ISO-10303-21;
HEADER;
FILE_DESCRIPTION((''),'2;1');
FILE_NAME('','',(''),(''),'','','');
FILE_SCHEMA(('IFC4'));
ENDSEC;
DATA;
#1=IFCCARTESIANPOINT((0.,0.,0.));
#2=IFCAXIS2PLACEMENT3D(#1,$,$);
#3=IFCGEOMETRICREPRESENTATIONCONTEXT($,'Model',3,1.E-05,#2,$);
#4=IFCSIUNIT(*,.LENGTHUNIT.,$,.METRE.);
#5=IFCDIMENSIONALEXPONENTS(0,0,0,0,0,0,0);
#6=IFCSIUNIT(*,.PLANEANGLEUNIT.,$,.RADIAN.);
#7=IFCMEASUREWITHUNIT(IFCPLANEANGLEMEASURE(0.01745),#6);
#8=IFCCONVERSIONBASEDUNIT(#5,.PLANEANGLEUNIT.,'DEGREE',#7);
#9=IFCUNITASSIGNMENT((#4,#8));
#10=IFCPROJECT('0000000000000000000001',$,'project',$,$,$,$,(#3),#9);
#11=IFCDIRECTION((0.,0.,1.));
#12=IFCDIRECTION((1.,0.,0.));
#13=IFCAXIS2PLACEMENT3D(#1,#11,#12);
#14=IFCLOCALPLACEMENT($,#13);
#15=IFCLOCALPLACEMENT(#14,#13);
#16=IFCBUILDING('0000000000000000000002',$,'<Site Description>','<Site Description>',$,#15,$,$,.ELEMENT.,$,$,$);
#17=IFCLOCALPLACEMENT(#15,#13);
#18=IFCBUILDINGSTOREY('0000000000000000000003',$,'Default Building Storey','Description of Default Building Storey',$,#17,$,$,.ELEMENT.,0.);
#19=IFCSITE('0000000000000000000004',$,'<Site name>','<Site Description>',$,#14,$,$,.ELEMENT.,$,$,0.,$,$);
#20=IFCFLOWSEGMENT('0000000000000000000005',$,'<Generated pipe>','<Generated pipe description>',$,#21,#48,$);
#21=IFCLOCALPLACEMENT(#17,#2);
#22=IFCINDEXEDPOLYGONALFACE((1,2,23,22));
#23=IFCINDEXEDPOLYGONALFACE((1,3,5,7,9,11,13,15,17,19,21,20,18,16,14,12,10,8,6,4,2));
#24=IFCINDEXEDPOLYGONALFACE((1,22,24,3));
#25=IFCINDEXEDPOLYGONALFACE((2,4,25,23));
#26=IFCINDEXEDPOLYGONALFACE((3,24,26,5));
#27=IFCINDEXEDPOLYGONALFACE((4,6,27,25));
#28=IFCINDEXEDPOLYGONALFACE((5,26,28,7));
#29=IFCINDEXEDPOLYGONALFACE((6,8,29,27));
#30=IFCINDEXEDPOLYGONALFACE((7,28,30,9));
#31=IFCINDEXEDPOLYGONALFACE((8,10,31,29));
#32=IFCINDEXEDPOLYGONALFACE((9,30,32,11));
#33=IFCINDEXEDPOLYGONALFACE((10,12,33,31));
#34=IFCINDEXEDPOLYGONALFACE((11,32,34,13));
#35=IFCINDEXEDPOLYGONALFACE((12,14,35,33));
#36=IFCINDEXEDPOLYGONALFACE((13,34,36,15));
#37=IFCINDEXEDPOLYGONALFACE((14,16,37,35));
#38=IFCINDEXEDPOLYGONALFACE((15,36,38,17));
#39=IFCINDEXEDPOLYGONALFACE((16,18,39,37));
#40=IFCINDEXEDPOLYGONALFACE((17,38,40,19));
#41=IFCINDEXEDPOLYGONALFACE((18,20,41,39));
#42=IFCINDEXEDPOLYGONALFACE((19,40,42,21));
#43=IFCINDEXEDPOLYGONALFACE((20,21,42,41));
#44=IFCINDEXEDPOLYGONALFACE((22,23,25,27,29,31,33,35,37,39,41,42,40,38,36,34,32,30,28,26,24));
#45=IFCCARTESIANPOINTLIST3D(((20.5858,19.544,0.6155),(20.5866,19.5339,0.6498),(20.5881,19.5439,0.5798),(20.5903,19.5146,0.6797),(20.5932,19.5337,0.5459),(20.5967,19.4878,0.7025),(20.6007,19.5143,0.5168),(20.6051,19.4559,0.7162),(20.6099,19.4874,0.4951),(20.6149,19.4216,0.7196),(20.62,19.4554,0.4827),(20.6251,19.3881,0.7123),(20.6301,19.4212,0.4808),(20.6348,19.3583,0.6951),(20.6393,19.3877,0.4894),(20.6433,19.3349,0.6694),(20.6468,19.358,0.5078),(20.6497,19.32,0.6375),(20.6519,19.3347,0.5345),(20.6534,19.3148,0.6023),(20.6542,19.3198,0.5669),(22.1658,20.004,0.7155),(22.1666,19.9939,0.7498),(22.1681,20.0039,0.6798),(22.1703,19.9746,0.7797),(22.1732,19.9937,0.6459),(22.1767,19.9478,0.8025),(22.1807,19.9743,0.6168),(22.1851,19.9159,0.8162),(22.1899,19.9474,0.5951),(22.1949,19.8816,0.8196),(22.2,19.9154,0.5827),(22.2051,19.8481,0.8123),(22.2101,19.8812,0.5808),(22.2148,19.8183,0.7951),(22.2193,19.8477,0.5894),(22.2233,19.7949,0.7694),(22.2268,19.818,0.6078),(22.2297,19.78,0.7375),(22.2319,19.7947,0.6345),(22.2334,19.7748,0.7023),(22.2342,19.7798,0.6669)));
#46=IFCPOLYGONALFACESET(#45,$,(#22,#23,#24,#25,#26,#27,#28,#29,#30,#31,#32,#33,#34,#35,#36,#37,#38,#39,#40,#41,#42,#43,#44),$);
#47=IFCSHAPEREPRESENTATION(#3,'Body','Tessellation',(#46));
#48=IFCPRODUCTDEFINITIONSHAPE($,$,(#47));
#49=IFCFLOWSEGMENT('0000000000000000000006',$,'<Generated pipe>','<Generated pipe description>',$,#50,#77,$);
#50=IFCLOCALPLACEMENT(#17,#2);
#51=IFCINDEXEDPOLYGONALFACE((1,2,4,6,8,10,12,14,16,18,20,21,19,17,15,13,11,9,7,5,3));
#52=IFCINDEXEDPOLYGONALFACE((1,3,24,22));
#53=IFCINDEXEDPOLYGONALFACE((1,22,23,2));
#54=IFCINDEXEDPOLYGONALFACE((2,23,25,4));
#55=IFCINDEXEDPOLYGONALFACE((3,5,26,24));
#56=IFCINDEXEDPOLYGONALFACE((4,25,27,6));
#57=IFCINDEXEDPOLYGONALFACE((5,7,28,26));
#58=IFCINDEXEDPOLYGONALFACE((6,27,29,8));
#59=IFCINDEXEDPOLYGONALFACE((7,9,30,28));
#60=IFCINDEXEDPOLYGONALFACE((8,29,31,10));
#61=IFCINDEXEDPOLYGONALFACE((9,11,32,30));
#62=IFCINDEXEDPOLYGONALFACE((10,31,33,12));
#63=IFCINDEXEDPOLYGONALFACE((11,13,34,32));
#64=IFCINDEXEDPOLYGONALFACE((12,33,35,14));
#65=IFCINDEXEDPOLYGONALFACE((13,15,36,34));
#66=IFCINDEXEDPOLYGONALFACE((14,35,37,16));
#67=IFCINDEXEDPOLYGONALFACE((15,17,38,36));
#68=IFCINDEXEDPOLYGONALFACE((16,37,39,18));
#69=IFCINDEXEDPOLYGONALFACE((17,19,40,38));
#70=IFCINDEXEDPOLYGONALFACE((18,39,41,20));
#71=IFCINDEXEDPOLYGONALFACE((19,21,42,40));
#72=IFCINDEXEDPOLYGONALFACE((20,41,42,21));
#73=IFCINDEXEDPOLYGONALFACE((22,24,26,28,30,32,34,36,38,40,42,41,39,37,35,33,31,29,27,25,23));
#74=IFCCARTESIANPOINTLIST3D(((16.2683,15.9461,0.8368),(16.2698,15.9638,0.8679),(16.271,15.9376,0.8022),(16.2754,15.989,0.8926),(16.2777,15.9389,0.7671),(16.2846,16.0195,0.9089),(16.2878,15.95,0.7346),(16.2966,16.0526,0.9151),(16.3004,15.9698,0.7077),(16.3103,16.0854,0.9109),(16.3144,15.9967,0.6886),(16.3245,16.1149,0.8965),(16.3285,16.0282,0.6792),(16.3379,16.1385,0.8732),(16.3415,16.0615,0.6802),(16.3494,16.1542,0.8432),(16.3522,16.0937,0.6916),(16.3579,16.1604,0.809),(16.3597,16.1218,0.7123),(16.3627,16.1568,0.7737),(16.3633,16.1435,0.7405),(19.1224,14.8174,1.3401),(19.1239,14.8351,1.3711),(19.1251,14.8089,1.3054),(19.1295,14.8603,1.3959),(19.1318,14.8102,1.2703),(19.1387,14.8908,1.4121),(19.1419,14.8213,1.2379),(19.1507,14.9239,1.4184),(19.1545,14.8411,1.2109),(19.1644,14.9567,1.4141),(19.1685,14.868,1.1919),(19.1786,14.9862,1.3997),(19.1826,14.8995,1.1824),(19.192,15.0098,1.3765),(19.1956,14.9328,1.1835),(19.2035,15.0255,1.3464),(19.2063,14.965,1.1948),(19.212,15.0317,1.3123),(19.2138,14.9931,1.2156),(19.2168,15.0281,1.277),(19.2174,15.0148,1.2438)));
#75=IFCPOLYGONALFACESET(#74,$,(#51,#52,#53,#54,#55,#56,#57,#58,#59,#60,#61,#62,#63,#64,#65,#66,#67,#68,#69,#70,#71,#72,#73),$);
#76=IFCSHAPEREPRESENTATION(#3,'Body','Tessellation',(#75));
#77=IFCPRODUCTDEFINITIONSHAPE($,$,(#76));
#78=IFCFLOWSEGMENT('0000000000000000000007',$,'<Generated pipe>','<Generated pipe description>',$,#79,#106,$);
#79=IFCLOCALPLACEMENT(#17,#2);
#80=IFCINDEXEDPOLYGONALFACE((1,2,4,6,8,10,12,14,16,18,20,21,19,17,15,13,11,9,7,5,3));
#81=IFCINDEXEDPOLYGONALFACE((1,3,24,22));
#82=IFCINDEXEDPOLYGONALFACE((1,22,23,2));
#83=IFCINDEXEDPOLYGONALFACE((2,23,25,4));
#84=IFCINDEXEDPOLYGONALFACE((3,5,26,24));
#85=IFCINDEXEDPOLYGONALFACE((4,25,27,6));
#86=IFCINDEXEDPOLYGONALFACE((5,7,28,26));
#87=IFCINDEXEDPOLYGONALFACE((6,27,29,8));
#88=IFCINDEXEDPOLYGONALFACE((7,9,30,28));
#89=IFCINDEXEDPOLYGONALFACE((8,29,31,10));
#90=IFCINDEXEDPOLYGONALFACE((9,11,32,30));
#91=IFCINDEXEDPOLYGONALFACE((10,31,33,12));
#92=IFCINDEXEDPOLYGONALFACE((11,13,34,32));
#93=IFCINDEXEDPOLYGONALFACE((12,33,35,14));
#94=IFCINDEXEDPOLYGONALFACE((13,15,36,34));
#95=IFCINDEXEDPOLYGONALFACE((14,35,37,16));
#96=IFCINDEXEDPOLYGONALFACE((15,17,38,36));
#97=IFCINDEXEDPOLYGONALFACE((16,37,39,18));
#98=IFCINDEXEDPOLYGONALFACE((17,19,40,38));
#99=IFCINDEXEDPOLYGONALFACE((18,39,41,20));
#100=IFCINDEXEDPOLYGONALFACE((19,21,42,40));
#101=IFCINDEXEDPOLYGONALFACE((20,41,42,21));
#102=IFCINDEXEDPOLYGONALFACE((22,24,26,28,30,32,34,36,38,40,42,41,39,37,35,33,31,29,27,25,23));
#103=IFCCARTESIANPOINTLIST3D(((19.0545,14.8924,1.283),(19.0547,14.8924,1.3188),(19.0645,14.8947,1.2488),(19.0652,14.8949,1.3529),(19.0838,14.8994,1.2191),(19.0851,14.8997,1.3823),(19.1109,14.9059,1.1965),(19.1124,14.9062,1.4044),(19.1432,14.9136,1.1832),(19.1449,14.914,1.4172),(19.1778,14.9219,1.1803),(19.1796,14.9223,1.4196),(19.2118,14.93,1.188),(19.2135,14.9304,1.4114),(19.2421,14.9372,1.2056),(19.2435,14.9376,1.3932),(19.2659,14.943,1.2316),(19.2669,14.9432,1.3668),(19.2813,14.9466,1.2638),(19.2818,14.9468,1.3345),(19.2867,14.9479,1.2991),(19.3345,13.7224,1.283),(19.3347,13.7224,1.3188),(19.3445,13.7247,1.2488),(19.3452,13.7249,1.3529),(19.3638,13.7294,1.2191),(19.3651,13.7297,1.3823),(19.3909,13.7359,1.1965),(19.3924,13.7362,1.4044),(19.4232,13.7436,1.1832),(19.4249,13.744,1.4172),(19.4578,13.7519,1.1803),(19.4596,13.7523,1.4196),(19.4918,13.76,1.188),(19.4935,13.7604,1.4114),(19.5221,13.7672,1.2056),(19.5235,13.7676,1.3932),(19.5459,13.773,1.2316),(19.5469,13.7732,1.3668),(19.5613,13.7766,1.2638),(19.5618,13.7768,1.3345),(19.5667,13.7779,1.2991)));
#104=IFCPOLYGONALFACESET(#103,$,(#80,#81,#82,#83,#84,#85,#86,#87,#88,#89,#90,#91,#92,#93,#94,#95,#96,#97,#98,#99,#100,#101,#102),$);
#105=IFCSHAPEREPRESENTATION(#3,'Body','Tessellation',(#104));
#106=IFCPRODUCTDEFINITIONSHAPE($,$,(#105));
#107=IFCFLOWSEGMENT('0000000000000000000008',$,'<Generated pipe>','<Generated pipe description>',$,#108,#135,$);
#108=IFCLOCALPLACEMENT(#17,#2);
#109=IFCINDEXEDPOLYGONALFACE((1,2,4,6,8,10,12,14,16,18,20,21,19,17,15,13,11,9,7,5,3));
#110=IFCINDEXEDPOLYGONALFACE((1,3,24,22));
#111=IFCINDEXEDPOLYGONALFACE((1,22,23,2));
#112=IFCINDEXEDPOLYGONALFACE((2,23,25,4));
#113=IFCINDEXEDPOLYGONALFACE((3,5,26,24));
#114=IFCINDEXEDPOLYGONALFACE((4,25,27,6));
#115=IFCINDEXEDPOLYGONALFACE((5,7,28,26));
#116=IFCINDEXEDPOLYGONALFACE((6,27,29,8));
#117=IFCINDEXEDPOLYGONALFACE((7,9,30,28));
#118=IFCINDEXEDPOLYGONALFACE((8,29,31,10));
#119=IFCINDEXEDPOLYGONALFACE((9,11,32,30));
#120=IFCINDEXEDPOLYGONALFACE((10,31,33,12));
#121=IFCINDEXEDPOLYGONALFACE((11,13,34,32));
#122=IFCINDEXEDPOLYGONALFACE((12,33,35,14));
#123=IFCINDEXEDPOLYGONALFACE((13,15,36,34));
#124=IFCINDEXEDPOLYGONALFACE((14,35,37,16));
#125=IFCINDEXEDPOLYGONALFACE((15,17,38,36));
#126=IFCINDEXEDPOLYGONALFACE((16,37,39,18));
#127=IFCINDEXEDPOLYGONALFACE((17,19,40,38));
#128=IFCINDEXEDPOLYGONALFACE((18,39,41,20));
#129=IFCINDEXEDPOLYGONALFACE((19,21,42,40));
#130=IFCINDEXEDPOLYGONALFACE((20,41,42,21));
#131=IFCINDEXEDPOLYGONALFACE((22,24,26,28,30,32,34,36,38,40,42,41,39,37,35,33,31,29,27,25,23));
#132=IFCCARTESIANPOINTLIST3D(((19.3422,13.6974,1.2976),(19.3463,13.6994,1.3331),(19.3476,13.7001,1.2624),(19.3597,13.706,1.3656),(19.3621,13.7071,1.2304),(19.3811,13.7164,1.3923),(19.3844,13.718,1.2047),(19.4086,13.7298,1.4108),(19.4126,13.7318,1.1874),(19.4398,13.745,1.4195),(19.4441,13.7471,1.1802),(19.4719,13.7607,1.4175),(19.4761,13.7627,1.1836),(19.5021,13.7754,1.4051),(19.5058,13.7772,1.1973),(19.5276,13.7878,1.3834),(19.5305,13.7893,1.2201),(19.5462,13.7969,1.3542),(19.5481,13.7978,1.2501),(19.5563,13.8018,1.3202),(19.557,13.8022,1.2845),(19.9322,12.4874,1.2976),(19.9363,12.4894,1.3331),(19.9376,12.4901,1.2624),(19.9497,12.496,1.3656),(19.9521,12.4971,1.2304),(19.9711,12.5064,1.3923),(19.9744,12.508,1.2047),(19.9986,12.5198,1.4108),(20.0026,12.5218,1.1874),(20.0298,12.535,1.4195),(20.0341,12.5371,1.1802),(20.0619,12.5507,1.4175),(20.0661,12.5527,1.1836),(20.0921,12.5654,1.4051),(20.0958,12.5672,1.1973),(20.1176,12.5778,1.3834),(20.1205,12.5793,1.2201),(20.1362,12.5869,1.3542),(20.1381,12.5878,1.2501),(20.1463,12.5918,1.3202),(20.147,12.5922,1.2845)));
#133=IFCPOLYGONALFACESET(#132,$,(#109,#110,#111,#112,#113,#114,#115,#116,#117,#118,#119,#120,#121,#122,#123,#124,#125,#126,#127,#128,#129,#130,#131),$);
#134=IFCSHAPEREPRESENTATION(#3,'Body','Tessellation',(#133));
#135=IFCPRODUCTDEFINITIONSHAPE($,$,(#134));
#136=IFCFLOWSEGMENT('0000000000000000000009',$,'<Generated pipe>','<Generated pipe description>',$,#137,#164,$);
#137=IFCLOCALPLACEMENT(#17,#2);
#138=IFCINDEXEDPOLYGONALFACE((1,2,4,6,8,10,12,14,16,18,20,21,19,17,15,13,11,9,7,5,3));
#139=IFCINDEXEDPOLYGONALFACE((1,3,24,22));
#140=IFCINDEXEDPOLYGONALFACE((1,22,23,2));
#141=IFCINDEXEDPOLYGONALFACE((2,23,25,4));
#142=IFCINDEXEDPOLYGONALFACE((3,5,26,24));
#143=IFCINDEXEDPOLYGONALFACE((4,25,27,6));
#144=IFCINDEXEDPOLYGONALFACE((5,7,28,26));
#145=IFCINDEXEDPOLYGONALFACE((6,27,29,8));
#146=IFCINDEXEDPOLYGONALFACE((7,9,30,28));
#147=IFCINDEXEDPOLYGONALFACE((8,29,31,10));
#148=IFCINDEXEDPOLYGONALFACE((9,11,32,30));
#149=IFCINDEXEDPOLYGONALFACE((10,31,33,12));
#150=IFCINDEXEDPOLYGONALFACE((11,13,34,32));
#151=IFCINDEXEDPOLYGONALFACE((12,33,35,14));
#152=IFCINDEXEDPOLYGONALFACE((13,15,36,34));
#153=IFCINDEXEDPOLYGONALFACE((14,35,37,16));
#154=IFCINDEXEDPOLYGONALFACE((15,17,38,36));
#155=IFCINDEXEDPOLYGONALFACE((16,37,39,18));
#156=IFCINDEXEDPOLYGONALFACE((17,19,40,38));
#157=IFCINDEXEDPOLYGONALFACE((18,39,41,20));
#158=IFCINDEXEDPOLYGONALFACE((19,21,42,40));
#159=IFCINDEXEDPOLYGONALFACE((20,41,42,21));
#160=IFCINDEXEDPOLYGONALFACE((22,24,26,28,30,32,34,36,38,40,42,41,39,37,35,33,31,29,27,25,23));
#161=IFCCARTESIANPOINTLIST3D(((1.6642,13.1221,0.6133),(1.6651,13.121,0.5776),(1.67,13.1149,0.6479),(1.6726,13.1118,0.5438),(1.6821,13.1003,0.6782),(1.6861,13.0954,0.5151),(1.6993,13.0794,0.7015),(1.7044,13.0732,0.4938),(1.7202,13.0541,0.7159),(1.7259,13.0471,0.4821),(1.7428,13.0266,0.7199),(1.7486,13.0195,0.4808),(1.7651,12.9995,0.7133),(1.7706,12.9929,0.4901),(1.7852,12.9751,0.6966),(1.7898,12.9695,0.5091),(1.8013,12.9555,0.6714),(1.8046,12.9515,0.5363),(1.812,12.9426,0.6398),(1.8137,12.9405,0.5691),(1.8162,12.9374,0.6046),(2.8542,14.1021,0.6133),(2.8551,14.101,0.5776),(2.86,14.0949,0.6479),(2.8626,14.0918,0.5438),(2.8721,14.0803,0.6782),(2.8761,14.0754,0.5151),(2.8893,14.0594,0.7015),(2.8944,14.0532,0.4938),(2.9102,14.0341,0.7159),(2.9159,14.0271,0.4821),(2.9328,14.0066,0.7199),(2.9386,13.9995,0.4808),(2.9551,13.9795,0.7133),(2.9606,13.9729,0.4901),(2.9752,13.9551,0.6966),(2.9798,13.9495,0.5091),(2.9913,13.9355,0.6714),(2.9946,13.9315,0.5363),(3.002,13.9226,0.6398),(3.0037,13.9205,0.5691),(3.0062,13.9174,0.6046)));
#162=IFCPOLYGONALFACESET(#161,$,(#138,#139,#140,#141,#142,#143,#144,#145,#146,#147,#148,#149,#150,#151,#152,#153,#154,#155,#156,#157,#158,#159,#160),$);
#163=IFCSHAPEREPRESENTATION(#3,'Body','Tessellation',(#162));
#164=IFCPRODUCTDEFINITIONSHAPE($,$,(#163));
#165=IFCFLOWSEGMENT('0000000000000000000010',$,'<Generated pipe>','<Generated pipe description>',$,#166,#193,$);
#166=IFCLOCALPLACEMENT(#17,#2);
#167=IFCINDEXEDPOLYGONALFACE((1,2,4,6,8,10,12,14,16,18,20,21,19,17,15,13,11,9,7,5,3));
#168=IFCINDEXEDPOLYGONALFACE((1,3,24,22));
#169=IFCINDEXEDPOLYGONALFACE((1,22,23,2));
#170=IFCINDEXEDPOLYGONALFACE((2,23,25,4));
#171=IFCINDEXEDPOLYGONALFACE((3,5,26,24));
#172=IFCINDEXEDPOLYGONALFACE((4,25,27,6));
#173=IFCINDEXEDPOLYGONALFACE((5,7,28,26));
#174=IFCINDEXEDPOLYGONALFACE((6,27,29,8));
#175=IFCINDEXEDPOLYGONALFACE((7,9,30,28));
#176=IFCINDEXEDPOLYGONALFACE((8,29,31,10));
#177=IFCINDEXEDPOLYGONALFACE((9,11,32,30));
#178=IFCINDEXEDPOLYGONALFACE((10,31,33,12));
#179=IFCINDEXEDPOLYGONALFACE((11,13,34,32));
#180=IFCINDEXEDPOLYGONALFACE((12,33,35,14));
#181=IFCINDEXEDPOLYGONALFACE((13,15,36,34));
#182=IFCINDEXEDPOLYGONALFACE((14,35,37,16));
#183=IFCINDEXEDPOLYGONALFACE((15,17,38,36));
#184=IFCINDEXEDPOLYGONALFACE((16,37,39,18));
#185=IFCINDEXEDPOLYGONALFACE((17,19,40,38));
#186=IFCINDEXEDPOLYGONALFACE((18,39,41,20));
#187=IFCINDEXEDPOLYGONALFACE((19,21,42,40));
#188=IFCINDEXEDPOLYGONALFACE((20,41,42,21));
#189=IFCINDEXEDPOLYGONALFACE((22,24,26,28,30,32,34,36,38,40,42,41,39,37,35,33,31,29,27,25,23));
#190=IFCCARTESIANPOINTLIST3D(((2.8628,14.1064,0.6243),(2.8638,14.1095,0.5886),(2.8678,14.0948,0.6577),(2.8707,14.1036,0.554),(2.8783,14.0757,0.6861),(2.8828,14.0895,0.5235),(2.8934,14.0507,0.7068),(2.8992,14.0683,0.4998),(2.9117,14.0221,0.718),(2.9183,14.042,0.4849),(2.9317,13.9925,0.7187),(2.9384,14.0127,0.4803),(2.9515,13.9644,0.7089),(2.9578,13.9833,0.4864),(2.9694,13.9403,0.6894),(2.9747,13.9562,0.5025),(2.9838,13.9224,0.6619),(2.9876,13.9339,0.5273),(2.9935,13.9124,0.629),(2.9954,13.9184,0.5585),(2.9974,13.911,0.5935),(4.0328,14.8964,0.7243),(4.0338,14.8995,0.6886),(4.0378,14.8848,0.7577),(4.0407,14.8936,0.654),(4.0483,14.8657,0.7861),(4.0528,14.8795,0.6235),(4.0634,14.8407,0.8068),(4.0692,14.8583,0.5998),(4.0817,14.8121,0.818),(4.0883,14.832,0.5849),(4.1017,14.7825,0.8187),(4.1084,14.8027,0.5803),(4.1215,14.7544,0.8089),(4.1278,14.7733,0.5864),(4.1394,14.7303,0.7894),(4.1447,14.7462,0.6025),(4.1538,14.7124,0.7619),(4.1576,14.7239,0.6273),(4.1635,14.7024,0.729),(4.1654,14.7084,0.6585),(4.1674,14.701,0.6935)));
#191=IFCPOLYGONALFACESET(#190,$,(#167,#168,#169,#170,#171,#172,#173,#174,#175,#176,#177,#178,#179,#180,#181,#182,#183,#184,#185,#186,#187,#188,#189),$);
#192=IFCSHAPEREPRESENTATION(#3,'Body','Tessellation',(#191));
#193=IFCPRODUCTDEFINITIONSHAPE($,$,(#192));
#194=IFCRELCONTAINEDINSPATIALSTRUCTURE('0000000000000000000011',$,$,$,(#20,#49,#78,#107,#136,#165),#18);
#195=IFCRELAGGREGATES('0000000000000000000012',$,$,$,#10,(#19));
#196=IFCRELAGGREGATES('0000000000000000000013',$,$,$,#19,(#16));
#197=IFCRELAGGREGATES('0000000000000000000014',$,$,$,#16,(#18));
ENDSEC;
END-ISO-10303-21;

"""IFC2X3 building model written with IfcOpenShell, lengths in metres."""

from ifc_helpers import new_model, entity, si_unit, converted_unit, frame, origin, origin_with_axes, origin_2d_with_axis, place, context, project, spatial, circle, extrude, element, save


model = new_model("IFC2X3")

# Units and contexts
model_context = context("Model", 3, precision=1e-05, world=origin())
ifc_project = project(units=[si_unit("LENGTHUNIT", "METRE"), converted_unit("PLANEANGLEUNIT", "DEGREE", entity("IfcPlaneAngleMeasure", 0.01745), si_unit("PLANEANGLEUNIT", "RADIAN"), dimensions=[0, 0, 0, 0, 0, 0, 0])], contexts=[model_context])

# Site, building, storey
site_placement = place(None, origin_with_axes())
site = spatial("IfcSite", under=ifc_project, at=site_placement, Name="<Site name>", Description="<Site Description>", CompositionType="ELEMENT", RefElevation=0.0)
building_placement = place(site_placement, origin_with_axes())
building = spatial("IfcBuilding", under=site, at=building_placement, Name="<Site Description>", Description="<Site Description>", CompositionType="ELEMENT")
storey_placement = place(building_placement, origin_with_axes())
storey = spatial("IfcBuildingStorey", under=building, at=storey_placement, Name="Default Building Storey", Description="Description of Default Building Storey", CompositionType="ELEMENT", Elevation=0.0)

# Flow segments
flow_segment_1_placement = place(storey_placement, frame((20.62, 19.43, 0.6), z_axis=(0.958368, 0.279019, 0.060656), x_axis=(-0.124035, 0.215469, 0.968601)))
element("IfcFlowSegment", 1, at=flow_segment_1_placement, inside=storey, Name="<Generated pipe>", Description="<Generated pipe description>", context=model_context, shape_type="SweptSolid", body=[
    extrude(circle(Radius=0.12, at=origin_2d_with_axis()), origin_with_axes(), (0.0, 0.0, 1.0), 1.6486),
])
flow_segment_2_placement = place(storey_placement, frame((16.3159, 16.0487, 0.7968), z_axis=(0.91767, -0.362907, 0.161806), x_axis=(-0.046782, 0.305707, 0.950976)))
element("IfcFlowSegment", 2, at=flow_segment_2_placement, inside=storey, Name="<Generated pipe>", Description="<Generated pipe description>", context=model_context, shape_type="SweptSolid", body=[
    extrude(circle(Radius=0.12, at=origin_2d_with_axis()), origin_with_axes(), (0.0, 0.0, 1.0), 3.1102),
])
flow_segment_3_placement = place(storey_placement, frame((19.17, 14.92, 1.3), z_axis=(0.232744, -0.972538, 0.0), x_axis=(0.612131, 0.146493, 0.777069)))
element("IfcFlowSegment", 3, at=flow_segment_3_placement, inside=storey, Name="<Generated pipe>", Description="<Generated pipe description>", context=model_context, shape_type="SweptSolid", body=[
    extrude(circle(Radius=0.12, at=origin_2d_with_axis()), origin_with_axes(), (0.0, 0.0, 1.0), 1.203),
])
flow_segment_4_placement = place(storey_placement, frame((19.45, 13.75, 1.3), z_axis=(0.438277, -0.89884, 0.0), x_axis=(0.433825, 0.211535, 0.875813)))
element("IfcFlowSegment", 4, at=flow_segment_4_placement, inside=storey, Name="<Generated pipe>", Description="<Generated pipe description>", context=model_context, shape_type="SweptSolid", body=[
    extrude(circle(Radius=0.12, at=origin_2d_with_axis()), origin_with_axes(), (0.0, 0.0, 1.0), 1.3462),
])
flow_segment_5_placement = place(storey_placement, frame((1.74, 13.03, 0.6), z_axis=(0.77193, 0.635707, 0.0), x_axis=(0.599796, -0.728324, 0.331345)))
element("IfcFlowSegment", 5, at=flow_segment_5_placement, inside=storey, Name="<Generated pipe>", Description="<Generated pipe description>", context=model_context, shape_type="SweptSolid", body=[
    extrude(circle(Radius=0.12, at=origin_2d_with_axis()), origin_with_axes(), (0.0, 0.0, 1.0), 1.5416),
])
flow_segment_6_placement = place(storey_placement, frame((2.93, 14.01, 0.6), z_axis=(0.826695, 0.558196, 0.070658), x_axis=(-0.559842, 0.803528, 0.202286)))
element("IfcFlowSegment", 6, at=flow_segment_6_placement, inside=storey, Name="<Generated pipe>", Description="<Generated pipe description>", context=model_context, shape_type="SweptSolid", body=[
    extrude(circle(Radius=0.12, at=origin_2d_with_axis()), origin_with_axes(), (0.0, 0.0, 1.0), 1.4153),
])

save(model, "model.ifc")
